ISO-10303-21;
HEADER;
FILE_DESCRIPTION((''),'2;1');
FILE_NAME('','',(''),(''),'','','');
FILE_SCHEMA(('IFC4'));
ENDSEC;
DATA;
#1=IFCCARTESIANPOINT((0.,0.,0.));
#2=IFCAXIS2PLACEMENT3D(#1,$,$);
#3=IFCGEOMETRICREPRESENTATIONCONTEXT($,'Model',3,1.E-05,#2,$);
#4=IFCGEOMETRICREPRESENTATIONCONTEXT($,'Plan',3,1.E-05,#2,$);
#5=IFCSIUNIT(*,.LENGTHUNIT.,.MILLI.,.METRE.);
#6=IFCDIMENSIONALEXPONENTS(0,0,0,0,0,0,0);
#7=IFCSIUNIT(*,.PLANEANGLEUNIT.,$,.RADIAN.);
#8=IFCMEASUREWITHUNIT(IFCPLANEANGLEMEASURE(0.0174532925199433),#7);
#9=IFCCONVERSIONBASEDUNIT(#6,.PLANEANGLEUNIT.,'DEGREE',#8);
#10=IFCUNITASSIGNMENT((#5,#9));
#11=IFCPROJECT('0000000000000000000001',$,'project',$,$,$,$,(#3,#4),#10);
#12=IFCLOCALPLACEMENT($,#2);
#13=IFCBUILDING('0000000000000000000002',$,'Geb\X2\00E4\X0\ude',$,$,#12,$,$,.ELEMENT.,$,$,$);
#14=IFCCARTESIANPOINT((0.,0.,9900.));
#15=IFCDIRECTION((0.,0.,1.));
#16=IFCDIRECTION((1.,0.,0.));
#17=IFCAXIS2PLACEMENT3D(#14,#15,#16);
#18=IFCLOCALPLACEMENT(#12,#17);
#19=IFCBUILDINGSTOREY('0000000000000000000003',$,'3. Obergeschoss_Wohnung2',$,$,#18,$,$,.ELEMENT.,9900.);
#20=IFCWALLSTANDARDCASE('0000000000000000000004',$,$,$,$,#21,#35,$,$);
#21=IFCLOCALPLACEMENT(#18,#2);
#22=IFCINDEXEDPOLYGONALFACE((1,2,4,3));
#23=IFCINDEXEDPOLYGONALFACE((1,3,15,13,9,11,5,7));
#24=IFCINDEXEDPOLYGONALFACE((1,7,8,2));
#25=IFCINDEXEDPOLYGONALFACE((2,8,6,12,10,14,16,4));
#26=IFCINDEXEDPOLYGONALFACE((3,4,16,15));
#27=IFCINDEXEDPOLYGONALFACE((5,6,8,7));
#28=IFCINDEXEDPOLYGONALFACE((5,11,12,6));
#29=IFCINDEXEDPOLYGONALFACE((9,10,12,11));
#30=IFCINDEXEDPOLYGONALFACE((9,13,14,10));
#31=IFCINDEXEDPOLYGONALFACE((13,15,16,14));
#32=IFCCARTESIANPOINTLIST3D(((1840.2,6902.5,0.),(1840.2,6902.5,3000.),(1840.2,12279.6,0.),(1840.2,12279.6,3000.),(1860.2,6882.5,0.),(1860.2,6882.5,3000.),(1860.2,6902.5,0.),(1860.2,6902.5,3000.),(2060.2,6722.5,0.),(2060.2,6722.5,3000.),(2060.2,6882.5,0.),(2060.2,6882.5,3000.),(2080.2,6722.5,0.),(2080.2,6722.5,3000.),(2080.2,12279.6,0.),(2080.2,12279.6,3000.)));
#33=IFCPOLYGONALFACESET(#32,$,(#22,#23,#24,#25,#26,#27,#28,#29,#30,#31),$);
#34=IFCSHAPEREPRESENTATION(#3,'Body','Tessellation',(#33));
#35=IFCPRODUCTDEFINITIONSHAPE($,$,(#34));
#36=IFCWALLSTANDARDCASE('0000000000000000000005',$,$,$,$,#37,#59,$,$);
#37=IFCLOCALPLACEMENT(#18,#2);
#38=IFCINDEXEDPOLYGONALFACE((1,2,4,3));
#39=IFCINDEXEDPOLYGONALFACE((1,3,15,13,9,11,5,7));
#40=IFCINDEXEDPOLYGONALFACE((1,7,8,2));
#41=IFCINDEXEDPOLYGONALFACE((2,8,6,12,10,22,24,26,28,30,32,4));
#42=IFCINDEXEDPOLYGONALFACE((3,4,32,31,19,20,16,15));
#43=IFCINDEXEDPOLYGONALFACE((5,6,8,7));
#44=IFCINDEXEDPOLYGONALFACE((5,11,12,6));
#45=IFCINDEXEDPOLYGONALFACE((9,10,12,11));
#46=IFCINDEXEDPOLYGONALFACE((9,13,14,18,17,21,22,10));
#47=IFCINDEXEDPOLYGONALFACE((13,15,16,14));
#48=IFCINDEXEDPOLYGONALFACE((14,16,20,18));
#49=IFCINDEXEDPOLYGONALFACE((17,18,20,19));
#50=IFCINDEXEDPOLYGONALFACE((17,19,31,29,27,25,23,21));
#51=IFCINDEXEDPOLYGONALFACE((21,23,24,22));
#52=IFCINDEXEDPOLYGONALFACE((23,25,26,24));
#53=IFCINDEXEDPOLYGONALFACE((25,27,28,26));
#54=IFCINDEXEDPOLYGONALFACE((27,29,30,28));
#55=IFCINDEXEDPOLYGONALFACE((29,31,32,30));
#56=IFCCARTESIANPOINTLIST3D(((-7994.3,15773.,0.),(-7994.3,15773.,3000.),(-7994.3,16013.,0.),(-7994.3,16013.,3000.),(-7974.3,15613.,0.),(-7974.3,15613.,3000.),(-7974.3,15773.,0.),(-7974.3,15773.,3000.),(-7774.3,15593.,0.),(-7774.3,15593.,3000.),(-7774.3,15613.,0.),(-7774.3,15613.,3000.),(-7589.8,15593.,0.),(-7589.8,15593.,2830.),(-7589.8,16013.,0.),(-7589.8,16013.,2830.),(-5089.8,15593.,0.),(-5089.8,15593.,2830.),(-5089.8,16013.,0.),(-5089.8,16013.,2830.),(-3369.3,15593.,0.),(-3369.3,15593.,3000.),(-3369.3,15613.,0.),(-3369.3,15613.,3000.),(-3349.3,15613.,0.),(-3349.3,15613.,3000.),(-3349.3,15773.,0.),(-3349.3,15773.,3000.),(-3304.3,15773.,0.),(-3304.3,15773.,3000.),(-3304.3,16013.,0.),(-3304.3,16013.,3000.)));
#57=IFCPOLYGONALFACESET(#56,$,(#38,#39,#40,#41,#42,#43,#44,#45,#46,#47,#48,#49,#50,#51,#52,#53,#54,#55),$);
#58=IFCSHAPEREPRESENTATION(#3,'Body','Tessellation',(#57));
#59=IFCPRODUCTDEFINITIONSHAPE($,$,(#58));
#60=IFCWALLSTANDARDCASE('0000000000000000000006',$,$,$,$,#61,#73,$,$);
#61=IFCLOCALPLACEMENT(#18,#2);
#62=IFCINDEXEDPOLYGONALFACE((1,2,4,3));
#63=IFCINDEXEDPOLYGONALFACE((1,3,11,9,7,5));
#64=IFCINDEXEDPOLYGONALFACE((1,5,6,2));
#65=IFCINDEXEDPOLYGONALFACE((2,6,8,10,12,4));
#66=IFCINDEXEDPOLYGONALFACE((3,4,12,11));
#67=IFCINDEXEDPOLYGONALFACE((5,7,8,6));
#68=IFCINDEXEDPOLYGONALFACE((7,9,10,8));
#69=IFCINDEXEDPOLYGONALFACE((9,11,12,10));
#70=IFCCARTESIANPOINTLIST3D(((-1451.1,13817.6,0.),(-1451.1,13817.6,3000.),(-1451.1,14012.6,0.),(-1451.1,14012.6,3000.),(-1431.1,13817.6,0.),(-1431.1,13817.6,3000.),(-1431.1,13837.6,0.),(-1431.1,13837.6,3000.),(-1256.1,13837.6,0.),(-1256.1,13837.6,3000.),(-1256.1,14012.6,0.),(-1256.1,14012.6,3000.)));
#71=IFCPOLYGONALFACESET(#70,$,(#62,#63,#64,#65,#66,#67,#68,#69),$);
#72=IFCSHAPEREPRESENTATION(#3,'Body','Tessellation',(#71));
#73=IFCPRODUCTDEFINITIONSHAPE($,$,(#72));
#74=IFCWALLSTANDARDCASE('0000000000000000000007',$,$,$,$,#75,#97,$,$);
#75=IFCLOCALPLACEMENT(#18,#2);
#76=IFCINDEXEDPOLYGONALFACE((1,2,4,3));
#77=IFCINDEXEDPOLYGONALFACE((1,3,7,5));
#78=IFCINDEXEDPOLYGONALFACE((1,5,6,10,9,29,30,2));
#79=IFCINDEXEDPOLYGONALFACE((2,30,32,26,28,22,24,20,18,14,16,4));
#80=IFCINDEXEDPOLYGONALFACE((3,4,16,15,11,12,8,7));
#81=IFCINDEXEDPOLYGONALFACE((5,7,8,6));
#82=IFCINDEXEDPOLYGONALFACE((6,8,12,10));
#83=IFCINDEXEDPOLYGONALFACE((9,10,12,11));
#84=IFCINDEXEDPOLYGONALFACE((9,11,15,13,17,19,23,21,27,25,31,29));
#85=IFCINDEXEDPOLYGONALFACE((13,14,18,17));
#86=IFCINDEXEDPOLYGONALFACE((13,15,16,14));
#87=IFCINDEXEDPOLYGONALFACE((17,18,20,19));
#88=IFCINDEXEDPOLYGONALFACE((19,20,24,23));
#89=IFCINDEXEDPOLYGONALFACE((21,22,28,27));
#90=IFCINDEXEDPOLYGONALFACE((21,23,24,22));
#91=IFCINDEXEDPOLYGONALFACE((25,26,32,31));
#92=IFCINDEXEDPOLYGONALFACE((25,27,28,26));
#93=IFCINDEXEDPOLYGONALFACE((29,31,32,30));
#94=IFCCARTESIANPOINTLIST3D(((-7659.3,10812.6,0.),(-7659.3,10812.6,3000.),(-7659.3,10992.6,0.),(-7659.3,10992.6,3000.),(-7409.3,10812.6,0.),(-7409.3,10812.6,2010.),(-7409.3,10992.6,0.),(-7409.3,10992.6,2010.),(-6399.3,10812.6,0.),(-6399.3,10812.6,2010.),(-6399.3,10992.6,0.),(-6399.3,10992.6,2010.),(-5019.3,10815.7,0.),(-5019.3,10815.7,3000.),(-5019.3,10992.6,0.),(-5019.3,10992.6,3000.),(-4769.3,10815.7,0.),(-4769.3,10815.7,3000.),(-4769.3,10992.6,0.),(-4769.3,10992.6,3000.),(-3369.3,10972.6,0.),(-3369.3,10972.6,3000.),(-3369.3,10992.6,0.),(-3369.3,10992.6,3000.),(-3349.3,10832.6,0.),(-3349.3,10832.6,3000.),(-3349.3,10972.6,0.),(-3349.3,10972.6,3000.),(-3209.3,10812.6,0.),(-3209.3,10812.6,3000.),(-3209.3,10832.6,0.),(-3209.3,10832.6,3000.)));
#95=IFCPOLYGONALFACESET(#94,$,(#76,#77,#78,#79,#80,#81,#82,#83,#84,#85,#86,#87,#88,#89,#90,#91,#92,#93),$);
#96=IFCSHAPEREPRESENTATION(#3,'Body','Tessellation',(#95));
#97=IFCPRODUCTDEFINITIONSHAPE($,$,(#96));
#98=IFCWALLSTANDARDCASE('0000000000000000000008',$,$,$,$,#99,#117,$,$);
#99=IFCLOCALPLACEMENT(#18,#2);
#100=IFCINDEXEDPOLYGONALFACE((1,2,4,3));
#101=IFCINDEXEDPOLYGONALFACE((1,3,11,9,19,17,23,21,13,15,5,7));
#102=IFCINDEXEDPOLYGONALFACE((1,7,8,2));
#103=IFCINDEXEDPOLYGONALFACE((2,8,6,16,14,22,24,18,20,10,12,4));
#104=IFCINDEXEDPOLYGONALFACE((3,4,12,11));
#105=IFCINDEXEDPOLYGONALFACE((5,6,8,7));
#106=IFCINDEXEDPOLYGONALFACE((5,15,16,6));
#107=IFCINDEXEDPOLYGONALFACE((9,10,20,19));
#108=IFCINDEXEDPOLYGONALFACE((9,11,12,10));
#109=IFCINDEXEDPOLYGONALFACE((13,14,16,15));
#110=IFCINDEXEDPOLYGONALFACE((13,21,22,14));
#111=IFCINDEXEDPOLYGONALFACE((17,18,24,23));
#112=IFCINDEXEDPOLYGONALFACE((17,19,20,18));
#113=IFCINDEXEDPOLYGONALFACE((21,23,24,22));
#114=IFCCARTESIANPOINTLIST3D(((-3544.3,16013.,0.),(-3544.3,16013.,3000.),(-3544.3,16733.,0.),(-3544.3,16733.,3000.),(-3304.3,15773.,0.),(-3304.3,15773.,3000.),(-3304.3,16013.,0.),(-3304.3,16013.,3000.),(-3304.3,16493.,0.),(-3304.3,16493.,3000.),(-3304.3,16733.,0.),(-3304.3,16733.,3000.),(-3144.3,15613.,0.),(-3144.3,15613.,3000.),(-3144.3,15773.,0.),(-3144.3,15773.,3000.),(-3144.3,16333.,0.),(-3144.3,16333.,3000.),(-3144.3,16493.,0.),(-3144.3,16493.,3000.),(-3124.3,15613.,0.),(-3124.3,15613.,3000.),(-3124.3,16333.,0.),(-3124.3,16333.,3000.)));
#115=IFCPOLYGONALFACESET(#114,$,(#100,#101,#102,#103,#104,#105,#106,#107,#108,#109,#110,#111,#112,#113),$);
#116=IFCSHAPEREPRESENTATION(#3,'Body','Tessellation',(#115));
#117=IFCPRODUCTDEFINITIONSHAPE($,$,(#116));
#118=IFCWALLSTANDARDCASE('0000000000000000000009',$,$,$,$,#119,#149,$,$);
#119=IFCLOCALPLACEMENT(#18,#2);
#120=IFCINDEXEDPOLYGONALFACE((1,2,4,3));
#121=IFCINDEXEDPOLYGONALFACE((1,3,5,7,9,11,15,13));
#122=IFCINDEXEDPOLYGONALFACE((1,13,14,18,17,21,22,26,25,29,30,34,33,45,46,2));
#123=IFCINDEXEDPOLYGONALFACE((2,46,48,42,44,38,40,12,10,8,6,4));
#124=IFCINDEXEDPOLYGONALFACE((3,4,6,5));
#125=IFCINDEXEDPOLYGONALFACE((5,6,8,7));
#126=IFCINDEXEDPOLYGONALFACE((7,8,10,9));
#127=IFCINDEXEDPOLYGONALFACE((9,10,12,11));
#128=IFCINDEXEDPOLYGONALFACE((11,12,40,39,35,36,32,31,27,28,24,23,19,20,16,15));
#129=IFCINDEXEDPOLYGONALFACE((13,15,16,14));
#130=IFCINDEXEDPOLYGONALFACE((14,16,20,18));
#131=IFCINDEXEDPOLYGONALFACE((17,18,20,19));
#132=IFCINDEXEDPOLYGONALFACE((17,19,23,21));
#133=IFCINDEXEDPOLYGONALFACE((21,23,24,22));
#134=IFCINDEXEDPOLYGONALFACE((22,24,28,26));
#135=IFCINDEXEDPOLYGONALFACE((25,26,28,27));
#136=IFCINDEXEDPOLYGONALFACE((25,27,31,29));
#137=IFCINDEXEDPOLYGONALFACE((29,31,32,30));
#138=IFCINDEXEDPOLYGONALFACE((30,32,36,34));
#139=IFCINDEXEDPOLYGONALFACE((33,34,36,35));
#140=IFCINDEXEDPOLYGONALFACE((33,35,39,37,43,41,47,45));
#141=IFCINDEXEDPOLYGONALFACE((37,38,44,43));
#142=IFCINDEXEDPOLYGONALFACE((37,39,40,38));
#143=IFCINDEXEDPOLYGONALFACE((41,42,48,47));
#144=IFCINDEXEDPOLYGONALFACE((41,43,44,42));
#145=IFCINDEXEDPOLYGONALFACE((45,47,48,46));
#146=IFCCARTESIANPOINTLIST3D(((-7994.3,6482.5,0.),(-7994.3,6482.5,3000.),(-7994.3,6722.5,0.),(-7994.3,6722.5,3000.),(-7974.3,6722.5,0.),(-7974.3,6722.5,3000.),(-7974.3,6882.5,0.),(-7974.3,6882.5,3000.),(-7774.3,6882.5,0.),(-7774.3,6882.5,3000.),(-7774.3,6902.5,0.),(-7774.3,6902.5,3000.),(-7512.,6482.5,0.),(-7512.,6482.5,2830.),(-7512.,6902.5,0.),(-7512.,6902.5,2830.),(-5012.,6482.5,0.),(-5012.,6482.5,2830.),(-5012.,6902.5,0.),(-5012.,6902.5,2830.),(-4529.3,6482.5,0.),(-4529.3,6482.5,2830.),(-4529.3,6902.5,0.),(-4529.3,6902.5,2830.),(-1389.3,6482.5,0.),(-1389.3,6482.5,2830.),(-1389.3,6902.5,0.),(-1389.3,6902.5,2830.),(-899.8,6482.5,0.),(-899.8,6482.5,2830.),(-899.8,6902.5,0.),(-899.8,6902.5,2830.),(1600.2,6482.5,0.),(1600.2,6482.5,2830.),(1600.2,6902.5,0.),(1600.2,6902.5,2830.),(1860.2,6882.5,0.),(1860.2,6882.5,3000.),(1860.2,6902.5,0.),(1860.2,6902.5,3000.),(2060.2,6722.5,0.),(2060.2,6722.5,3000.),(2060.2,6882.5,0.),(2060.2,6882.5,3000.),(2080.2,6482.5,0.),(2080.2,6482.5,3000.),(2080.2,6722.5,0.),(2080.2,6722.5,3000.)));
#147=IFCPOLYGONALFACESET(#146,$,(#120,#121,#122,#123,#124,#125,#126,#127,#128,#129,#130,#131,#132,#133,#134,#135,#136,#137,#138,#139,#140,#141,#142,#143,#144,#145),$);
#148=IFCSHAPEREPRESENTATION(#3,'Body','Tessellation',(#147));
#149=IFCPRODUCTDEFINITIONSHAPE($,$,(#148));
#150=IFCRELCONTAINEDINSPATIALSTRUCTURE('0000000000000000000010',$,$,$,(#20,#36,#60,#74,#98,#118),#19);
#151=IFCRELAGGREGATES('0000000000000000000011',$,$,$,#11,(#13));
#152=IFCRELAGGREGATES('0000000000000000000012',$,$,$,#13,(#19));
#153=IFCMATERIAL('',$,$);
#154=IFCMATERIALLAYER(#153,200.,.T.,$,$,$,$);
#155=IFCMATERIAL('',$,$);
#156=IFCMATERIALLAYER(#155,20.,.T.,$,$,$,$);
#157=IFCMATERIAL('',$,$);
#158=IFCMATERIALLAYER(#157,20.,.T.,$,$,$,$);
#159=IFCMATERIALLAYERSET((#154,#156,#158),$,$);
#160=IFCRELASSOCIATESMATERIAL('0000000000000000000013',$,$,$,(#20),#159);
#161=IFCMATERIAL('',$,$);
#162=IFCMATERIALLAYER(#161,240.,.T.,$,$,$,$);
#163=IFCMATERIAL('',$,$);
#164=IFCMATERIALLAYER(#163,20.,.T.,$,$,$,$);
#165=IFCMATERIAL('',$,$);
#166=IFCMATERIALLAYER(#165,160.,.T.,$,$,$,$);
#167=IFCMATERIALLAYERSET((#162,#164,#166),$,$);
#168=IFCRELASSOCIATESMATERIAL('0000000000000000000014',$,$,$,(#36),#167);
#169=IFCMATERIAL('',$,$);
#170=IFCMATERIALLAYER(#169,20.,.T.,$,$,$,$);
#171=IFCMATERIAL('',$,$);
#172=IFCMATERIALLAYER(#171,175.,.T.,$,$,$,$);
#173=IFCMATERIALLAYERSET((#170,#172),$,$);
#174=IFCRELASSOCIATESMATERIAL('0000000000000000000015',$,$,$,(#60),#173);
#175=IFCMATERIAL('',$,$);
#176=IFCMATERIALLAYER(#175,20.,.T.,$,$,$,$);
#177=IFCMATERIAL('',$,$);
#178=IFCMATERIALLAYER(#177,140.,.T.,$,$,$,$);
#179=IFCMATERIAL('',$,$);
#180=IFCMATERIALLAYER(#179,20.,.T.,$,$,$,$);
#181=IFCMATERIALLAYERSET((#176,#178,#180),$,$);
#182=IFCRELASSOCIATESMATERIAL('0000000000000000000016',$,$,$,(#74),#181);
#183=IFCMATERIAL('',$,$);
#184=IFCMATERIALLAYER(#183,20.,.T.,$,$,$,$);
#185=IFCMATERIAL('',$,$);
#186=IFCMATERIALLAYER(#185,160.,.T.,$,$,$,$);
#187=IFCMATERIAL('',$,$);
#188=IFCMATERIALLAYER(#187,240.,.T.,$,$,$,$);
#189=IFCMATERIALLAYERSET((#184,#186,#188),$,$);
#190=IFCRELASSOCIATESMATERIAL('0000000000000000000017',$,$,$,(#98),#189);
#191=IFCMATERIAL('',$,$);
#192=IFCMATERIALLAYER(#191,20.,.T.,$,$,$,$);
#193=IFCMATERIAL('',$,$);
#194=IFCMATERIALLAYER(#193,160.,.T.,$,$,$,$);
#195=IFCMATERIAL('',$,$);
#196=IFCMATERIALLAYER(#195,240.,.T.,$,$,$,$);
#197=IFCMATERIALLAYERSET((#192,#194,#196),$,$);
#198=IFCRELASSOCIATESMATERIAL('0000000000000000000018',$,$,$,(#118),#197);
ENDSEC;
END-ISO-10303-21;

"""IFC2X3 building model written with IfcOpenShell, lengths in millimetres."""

from ifc_helpers import new_model, entity, si_unit, converted_unit, frame, frame_2d, origin, origin_with_axes, place, context, project, spatial, polyline, rectangle, outline, extrude, material, layer, layer_set, layer_usage, element, save


model = new_model("IFC2X3")

# Units and contexts
model_context = context("Model", 3, precision=1e-05, world=origin())
plan_context = context("Plan", 3, precision=1e-05, world=origin())
ifc_project = project(units=[si_unit("LENGTHUNIT", "METRE", prefix="MILLI"), converted_unit("PLANEANGLEUNIT", "DEGREE", entity("IfcPlaneAngleMeasure", 0.0174532925199433), si_unit("PLANEANGLEUNIT", "RADIAN"), dimensions=[0, 0, 0, 0, 0, 0, 0])], contexts=[model_context, plan_context])

# Building, storey
building_placement = place(None, origin())
building = spatial("IfcBuilding", under=ifc_project, at=building_placement, Name="Gebäude", CompositionType="ELEMENT")
storey_placement = place(building_placement, frame((0.0, 0.0, 9900.0), z_axis=(0.0, 0.0, 1.0), x_axis=(1.0, 0.0, 0.0)))
storey = spatial("IfcBuildingStorey", under=building, at=storey_placement, Name="3. Obergeschoss_Wohnung2", CompositionType="ELEMENT", Elevation=9900.0)

# Wall
ifc_material_1 = material(Name="")
ifc_layer_1 = layer(ifc_material_1, 200.0, ventilated=True)
ifc_material_2 = material(Name="")
ifc_layer_2 = layer(ifc_material_2, 20.0, ventilated=True)
ifc_material_3 = material(Name="")
ifc_layer_3 = layer(ifc_material_3, 20.0, ventilated=True)
ifc_layer_set_1 = layer_set([ifc_layer_1, ifc_layer_2, ifc_layer_3])
ifc_layer_usage_1 = layer_usage(ifc_layer_set_1, "AXIS2", "POSITIVE", 0.0)
wall_1_placement = place(storey_placement, frame((2080.2, 6722.5, 0.0), z_axis=(0.0, 0.0, 1.0), x_axis=(0.0, 1.0, 0.0)))
element("IfcWallStandardCase", 1, at=wall_1_placement, inside=storey, material=ifc_layer_usage_1, context=model_context, shape_type="SweptSolid", body=[
    extrude(outline(polyline([(180.0, 240.0), (180.0, 220.0), (160.0, 220.0), (160.0, 20.0), (0.0, 20.0), (0.0, 0.0), (5557.1, 0.0), (5557.1, 240.0), (180.0, 240.0)])), origin_with_axes(), (0.0, 0.0, 1.0), 3000.0),
])

# Wall, opening
ifc_material_4 = material(Name="")
ifc_layer_4 = layer(ifc_material_4, 240.0, ventilated=True)
ifc_material_5 = material(Name="")
ifc_layer_5 = layer(ifc_material_5, 20.0, ventilated=True)
ifc_material_6 = material(Name="")
ifc_layer_6 = layer(ifc_material_6, 160.0, ventilated=True)
ifc_layer_set_2 = layer_set([ifc_layer_4, ifc_layer_5, ifc_layer_6])
ifc_layer_usage_2 = layer_usage(ifc_layer_set_2, "AXIS2", "POSITIVE", -420.0)
wall_2_placement = place(storey_placement, frame((-7774.3, 15593.0, 0.0), z_axis=(0.0, 0.0, 1.0), x_axis=(1.0, 0.0, 0.0)))
wall_2 = element("IfcWallStandardCase", 2, at=wall_2_placement, inside=storey, material=ifc_layer_usage_2, context=model_context, shape_type="SweptSolid", body=[
    extrude(outline(polyline([(0.0, 0.0), (4405.0, 0.0), (4405.0, 20.0), (4425.0, 20.0), (4425.0, 180.0), (4470.0, 180.0), (4470.0, 420.0), (-220.0, 420.0), (-220.0, 180.0), (-200.0, 180.0), (-200.0, 20.0), (0.0, 20.0), (0.0, 0.0)])), origin_with_axes(), (0.0, 0.0, 1.0), 3000.0),
])
opening_1_placement = place(wall_2_placement, frame((184.5, 0.0, 0.0), z_axis=(0.0, 1.0, 0.0), x_axis=(0.0, 0.0, 1.0)))
element("IfcOpeningElement", 3, at=opening_1_placement, cuts=wall_2, ObjectType="Opening", context=model_context, shape_type="SweptSolid", body=[
    extrude(rectangle(XDim=2830.0, YDim=2500.0, at=frame_2d((1415.0, 1250.0), x_axis=(1.0, 0.0))), origin_with_axes(), (0.0, 0.0, 1.0), 420.0),
])

# Wall
ifc_material_7 = material(Name="")
ifc_layer_7 = layer(ifc_material_7, 20.0, ventilated=True)
ifc_material_8 = material(Name="")
ifc_layer_8 = layer(ifc_material_8, 175.0, ventilated=True)
ifc_layer_set_3 = layer_set([ifc_layer_7, ifc_layer_8])
ifc_layer_usage_3 = layer_usage(ifc_layer_set_3, "AXIS2", "POSITIVE", -195.0)
wall_3_placement = place(storey_placement, frame((-1451.1, 13817.6, 0.0), z_axis=(0.0, 0.0, 1.0), x_axis=(1.0, 0.0, 0.0)))
element("IfcWallStandardCase", 4, at=wall_3_placement, inside=storey, material=ifc_layer_usage_3, context=model_context, shape_type="SweptSolid", body=[
    extrude(outline(polyline([(0.0, 0.0), (20.0, 0.0), (20.0, 20.0), (195.0, 20.0), (195.0, 195.0), (0.0, 195.0), (0.0, 0.0)])), origin_with_axes(), (0.0, 0.0, 1.0), 3000.0),
])

# Wall, opening
ifc_material_9 = material(Name="")
ifc_layer_9 = layer(ifc_material_9, 20.0, ventilated=True)
ifc_material_10 = material(Name="")
ifc_layer_10 = layer(ifc_material_10, 140.0, ventilated=True)
ifc_material_11 = material(Name="")
ifc_layer_11 = layer(ifc_material_11, 20.0, ventilated=True)
ifc_layer_set_4 = layer_set([ifc_layer_9, ifc_layer_10, ifc_layer_11])
ifc_layer_usage_4 = layer_usage(ifc_layer_set_4, "AXIS2", "POSITIVE", 0.0)
wall_4_placement = place(storey_placement, frame((-7659.3, 10812.6, 0.0), z_axis=(0.0, 0.0, 1.0), x_axis=(1.0, 0.0, 0.0)))
wall_4 = element("IfcWallStandardCase", 5, at=wall_4_placement, inside=storey, material=ifc_layer_usage_4, context=model_context, shape_type="SweptSolid", body=[
    extrude(outline(polyline([(2889.9, 3.1), (2639.9, 3.1), (2639.9, 180.0), (0.0, 180.0), (0.0, 0.0), (4450.0, 0.0), (4450.0, 20.0), (4310.0, 20.0), (4310.0, 160.0), (4290.0, 160.0), (4290.0, 180.0), (2889.9, 180.0), (2889.9, 3.1)])), origin_with_axes(), (0.0, 0.0, 1.0), 3000.0),
])
opening_2_placement = place(wall_4_placement, frame((250.0, 0.0, 0.0), z_axis=(0.0, 1.0, 0.0), x_axis=(0.0, 0.0, 1.0)))
element("IfcOpeningElement", 6, at=opening_2_placement, cuts=wall_4, ObjectType="Opening", context=model_context, shape_type="SweptSolid", body=[
    extrude(rectangle(XDim=2010.0, YDim=1010.0, at=frame_2d((1005.0, 505.0), x_axis=(1.0, 0.0))), origin_with_axes(), (0.0, 0.0, 1.0), 180.0),
])

# Wall
ifc_material_12 = material(Name="")
ifc_layer_12 = layer(ifc_material_12, 20.0, ventilated=True)
ifc_material_13 = material(Name="")
ifc_layer_13 = layer(ifc_material_13, 160.0, ventilated=True)
ifc_material_14 = material(Name="")
ifc_layer_14 = layer(ifc_material_14, 240.0, ventilated=True)
ifc_layer_set_5 = layer_set([ifc_layer_12, ifc_layer_13, ifc_layer_14])
ifc_layer_usage_5 = layer_usage(ifc_layer_set_5, "AXIS2", "POSITIVE", -420.0)
wall_5_placement = place(storey_placement, frame((-3124.3, 15613.0, 0.0), z_axis=(0.0, 0.0, 1.0), x_axis=(0.0, 1.0, 0.0)))
element("IfcWallStandardCase", 7, at=wall_5_placement, inside=storey, material=ifc_layer_usage_5, context=model_context, shape_type="SweptSolid", body=[
    extrude(outline(polyline([(0.0, 0.0), (720.0, 0.0), (720.0, 20.0), (880.0, 20.0), (880.0, 180.0), (1120.0, 180.0), (1120.0, 420.0), (400.0, 420.0), (400.0, 180.0), (160.0, 180.0), (160.0, 20.0), (0.0, 20.0), (0.0, 0.0)])), origin_with_axes(), (0.0, 0.0, 1.0), 3000.0),
])

# Wall, openings
ifc_material_15 = material(Name="")
ifc_layer_15 = layer(ifc_material_15, 20.0, ventilated=True)
ifc_material_16 = material(Name="")
ifc_layer_16 = layer(ifc_material_16, 160.0, ventilated=True)
ifc_material_17 = material(Name="")
ifc_layer_17 = layer(ifc_material_17, 240.0, ventilated=True)
ifc_layer_set_6 = layer_set([ifc_layer_15, ifc_layer_16, ifc_layer_17])
ifc_layer_usage_6 = layer_usage(ifc_layer_set_6, "AXIS2", "POSITIVE", -420.0)
wall_6_placement = place(storey_placement, frame((1860.2, 6902.5, 0.0), z_axis=(0.0, 0.0, 1.0), x_axis=(-1.0, 0.0, 0.0)))
wall_6 = element("IfcWallStandardCase", 8, at=wall_6_placement, inside=storey, material=ifc_layer_usage_6, context=model_context, shape_type="SweptSolid", body=[
    extrude(outline(polyline([(0.0, 0.0), (9634.5, 0.0), (9634.5, 20.0), (9834.5, 20.0), (9834.5, 180.0), (9854.5, 180.0), (9854.5, 420.0), (-220.0, 420.0), (-220.0, 180.0), (-200.0, 180.0), (-200.0, 20.0), (0.0, 20.0), (0.0, 0.0)])), origin_with_axes(), (0.0, 0.0, 1.0), 3000.0),
])
opening_3_placement = place(wall_6_placement, frame((6872.2, 0.0, 0.0), z_axis=(0.0, 1.0, 0.0), x_axis=(0.0, 0.0, 1.0)))
element("IfcOpeningElement", 9, at=opening_3_placement, cuts=wall_6, ObjectType="Opening", context=model_context, shape_type="SweptSolid", body=[
    extrude(rectangle(XDim=2830.0, YDim=2500.0, at=frame_2d((1415.0, 1250.0), x_axis=(1.0, 0.0))), origin_with_axes(), (0.0, 0.0, 1.0), 420.0),
])
opening_4_placement = place(wall_6_placement, frame((260.0, 0.0, 0.0), z_axis=(0.0, 1.0, 0.0), x_axis=(0.0, 0.0, 1.0)))
element("IfcOpeningElement", 10, at=opening_4_placement, cuts=wall_6, ObjectType="Opening", context=model_context, shape_type="SweptSolid", body=[
    extrude(rectangle(XDim=2830.0, YDim=2500.0, at=frame_2d((1415.0, 1250.0), x_axis=(1.0, 0.0))), origin_with_axes(), (0.0, 0.0, 1.0), 420.0),
])
opening_5_placement = place(wall_6_placement, frame((3249.5, 0.0, 0.0), z_axis=(0.0, 1.0, 0.0), x_axis=(0.0, 0.0, 1.0)))
element("IfcOpeningElement", 11, at=opening_5_placement, cuts=wall_6, ObjectType="Opening", context=model_context, shape_type="SweptSolid", body=[
    extrude(rectangle(XDim=2830.0, YDim=3140.0, at=frame_2d((1415.0, 1570.0), x_axis=(1.0, 0.0))), origin_with_axes(), (0.0, 0.0, 1.0), 420.0),
])

save(model, "model.ifc")
